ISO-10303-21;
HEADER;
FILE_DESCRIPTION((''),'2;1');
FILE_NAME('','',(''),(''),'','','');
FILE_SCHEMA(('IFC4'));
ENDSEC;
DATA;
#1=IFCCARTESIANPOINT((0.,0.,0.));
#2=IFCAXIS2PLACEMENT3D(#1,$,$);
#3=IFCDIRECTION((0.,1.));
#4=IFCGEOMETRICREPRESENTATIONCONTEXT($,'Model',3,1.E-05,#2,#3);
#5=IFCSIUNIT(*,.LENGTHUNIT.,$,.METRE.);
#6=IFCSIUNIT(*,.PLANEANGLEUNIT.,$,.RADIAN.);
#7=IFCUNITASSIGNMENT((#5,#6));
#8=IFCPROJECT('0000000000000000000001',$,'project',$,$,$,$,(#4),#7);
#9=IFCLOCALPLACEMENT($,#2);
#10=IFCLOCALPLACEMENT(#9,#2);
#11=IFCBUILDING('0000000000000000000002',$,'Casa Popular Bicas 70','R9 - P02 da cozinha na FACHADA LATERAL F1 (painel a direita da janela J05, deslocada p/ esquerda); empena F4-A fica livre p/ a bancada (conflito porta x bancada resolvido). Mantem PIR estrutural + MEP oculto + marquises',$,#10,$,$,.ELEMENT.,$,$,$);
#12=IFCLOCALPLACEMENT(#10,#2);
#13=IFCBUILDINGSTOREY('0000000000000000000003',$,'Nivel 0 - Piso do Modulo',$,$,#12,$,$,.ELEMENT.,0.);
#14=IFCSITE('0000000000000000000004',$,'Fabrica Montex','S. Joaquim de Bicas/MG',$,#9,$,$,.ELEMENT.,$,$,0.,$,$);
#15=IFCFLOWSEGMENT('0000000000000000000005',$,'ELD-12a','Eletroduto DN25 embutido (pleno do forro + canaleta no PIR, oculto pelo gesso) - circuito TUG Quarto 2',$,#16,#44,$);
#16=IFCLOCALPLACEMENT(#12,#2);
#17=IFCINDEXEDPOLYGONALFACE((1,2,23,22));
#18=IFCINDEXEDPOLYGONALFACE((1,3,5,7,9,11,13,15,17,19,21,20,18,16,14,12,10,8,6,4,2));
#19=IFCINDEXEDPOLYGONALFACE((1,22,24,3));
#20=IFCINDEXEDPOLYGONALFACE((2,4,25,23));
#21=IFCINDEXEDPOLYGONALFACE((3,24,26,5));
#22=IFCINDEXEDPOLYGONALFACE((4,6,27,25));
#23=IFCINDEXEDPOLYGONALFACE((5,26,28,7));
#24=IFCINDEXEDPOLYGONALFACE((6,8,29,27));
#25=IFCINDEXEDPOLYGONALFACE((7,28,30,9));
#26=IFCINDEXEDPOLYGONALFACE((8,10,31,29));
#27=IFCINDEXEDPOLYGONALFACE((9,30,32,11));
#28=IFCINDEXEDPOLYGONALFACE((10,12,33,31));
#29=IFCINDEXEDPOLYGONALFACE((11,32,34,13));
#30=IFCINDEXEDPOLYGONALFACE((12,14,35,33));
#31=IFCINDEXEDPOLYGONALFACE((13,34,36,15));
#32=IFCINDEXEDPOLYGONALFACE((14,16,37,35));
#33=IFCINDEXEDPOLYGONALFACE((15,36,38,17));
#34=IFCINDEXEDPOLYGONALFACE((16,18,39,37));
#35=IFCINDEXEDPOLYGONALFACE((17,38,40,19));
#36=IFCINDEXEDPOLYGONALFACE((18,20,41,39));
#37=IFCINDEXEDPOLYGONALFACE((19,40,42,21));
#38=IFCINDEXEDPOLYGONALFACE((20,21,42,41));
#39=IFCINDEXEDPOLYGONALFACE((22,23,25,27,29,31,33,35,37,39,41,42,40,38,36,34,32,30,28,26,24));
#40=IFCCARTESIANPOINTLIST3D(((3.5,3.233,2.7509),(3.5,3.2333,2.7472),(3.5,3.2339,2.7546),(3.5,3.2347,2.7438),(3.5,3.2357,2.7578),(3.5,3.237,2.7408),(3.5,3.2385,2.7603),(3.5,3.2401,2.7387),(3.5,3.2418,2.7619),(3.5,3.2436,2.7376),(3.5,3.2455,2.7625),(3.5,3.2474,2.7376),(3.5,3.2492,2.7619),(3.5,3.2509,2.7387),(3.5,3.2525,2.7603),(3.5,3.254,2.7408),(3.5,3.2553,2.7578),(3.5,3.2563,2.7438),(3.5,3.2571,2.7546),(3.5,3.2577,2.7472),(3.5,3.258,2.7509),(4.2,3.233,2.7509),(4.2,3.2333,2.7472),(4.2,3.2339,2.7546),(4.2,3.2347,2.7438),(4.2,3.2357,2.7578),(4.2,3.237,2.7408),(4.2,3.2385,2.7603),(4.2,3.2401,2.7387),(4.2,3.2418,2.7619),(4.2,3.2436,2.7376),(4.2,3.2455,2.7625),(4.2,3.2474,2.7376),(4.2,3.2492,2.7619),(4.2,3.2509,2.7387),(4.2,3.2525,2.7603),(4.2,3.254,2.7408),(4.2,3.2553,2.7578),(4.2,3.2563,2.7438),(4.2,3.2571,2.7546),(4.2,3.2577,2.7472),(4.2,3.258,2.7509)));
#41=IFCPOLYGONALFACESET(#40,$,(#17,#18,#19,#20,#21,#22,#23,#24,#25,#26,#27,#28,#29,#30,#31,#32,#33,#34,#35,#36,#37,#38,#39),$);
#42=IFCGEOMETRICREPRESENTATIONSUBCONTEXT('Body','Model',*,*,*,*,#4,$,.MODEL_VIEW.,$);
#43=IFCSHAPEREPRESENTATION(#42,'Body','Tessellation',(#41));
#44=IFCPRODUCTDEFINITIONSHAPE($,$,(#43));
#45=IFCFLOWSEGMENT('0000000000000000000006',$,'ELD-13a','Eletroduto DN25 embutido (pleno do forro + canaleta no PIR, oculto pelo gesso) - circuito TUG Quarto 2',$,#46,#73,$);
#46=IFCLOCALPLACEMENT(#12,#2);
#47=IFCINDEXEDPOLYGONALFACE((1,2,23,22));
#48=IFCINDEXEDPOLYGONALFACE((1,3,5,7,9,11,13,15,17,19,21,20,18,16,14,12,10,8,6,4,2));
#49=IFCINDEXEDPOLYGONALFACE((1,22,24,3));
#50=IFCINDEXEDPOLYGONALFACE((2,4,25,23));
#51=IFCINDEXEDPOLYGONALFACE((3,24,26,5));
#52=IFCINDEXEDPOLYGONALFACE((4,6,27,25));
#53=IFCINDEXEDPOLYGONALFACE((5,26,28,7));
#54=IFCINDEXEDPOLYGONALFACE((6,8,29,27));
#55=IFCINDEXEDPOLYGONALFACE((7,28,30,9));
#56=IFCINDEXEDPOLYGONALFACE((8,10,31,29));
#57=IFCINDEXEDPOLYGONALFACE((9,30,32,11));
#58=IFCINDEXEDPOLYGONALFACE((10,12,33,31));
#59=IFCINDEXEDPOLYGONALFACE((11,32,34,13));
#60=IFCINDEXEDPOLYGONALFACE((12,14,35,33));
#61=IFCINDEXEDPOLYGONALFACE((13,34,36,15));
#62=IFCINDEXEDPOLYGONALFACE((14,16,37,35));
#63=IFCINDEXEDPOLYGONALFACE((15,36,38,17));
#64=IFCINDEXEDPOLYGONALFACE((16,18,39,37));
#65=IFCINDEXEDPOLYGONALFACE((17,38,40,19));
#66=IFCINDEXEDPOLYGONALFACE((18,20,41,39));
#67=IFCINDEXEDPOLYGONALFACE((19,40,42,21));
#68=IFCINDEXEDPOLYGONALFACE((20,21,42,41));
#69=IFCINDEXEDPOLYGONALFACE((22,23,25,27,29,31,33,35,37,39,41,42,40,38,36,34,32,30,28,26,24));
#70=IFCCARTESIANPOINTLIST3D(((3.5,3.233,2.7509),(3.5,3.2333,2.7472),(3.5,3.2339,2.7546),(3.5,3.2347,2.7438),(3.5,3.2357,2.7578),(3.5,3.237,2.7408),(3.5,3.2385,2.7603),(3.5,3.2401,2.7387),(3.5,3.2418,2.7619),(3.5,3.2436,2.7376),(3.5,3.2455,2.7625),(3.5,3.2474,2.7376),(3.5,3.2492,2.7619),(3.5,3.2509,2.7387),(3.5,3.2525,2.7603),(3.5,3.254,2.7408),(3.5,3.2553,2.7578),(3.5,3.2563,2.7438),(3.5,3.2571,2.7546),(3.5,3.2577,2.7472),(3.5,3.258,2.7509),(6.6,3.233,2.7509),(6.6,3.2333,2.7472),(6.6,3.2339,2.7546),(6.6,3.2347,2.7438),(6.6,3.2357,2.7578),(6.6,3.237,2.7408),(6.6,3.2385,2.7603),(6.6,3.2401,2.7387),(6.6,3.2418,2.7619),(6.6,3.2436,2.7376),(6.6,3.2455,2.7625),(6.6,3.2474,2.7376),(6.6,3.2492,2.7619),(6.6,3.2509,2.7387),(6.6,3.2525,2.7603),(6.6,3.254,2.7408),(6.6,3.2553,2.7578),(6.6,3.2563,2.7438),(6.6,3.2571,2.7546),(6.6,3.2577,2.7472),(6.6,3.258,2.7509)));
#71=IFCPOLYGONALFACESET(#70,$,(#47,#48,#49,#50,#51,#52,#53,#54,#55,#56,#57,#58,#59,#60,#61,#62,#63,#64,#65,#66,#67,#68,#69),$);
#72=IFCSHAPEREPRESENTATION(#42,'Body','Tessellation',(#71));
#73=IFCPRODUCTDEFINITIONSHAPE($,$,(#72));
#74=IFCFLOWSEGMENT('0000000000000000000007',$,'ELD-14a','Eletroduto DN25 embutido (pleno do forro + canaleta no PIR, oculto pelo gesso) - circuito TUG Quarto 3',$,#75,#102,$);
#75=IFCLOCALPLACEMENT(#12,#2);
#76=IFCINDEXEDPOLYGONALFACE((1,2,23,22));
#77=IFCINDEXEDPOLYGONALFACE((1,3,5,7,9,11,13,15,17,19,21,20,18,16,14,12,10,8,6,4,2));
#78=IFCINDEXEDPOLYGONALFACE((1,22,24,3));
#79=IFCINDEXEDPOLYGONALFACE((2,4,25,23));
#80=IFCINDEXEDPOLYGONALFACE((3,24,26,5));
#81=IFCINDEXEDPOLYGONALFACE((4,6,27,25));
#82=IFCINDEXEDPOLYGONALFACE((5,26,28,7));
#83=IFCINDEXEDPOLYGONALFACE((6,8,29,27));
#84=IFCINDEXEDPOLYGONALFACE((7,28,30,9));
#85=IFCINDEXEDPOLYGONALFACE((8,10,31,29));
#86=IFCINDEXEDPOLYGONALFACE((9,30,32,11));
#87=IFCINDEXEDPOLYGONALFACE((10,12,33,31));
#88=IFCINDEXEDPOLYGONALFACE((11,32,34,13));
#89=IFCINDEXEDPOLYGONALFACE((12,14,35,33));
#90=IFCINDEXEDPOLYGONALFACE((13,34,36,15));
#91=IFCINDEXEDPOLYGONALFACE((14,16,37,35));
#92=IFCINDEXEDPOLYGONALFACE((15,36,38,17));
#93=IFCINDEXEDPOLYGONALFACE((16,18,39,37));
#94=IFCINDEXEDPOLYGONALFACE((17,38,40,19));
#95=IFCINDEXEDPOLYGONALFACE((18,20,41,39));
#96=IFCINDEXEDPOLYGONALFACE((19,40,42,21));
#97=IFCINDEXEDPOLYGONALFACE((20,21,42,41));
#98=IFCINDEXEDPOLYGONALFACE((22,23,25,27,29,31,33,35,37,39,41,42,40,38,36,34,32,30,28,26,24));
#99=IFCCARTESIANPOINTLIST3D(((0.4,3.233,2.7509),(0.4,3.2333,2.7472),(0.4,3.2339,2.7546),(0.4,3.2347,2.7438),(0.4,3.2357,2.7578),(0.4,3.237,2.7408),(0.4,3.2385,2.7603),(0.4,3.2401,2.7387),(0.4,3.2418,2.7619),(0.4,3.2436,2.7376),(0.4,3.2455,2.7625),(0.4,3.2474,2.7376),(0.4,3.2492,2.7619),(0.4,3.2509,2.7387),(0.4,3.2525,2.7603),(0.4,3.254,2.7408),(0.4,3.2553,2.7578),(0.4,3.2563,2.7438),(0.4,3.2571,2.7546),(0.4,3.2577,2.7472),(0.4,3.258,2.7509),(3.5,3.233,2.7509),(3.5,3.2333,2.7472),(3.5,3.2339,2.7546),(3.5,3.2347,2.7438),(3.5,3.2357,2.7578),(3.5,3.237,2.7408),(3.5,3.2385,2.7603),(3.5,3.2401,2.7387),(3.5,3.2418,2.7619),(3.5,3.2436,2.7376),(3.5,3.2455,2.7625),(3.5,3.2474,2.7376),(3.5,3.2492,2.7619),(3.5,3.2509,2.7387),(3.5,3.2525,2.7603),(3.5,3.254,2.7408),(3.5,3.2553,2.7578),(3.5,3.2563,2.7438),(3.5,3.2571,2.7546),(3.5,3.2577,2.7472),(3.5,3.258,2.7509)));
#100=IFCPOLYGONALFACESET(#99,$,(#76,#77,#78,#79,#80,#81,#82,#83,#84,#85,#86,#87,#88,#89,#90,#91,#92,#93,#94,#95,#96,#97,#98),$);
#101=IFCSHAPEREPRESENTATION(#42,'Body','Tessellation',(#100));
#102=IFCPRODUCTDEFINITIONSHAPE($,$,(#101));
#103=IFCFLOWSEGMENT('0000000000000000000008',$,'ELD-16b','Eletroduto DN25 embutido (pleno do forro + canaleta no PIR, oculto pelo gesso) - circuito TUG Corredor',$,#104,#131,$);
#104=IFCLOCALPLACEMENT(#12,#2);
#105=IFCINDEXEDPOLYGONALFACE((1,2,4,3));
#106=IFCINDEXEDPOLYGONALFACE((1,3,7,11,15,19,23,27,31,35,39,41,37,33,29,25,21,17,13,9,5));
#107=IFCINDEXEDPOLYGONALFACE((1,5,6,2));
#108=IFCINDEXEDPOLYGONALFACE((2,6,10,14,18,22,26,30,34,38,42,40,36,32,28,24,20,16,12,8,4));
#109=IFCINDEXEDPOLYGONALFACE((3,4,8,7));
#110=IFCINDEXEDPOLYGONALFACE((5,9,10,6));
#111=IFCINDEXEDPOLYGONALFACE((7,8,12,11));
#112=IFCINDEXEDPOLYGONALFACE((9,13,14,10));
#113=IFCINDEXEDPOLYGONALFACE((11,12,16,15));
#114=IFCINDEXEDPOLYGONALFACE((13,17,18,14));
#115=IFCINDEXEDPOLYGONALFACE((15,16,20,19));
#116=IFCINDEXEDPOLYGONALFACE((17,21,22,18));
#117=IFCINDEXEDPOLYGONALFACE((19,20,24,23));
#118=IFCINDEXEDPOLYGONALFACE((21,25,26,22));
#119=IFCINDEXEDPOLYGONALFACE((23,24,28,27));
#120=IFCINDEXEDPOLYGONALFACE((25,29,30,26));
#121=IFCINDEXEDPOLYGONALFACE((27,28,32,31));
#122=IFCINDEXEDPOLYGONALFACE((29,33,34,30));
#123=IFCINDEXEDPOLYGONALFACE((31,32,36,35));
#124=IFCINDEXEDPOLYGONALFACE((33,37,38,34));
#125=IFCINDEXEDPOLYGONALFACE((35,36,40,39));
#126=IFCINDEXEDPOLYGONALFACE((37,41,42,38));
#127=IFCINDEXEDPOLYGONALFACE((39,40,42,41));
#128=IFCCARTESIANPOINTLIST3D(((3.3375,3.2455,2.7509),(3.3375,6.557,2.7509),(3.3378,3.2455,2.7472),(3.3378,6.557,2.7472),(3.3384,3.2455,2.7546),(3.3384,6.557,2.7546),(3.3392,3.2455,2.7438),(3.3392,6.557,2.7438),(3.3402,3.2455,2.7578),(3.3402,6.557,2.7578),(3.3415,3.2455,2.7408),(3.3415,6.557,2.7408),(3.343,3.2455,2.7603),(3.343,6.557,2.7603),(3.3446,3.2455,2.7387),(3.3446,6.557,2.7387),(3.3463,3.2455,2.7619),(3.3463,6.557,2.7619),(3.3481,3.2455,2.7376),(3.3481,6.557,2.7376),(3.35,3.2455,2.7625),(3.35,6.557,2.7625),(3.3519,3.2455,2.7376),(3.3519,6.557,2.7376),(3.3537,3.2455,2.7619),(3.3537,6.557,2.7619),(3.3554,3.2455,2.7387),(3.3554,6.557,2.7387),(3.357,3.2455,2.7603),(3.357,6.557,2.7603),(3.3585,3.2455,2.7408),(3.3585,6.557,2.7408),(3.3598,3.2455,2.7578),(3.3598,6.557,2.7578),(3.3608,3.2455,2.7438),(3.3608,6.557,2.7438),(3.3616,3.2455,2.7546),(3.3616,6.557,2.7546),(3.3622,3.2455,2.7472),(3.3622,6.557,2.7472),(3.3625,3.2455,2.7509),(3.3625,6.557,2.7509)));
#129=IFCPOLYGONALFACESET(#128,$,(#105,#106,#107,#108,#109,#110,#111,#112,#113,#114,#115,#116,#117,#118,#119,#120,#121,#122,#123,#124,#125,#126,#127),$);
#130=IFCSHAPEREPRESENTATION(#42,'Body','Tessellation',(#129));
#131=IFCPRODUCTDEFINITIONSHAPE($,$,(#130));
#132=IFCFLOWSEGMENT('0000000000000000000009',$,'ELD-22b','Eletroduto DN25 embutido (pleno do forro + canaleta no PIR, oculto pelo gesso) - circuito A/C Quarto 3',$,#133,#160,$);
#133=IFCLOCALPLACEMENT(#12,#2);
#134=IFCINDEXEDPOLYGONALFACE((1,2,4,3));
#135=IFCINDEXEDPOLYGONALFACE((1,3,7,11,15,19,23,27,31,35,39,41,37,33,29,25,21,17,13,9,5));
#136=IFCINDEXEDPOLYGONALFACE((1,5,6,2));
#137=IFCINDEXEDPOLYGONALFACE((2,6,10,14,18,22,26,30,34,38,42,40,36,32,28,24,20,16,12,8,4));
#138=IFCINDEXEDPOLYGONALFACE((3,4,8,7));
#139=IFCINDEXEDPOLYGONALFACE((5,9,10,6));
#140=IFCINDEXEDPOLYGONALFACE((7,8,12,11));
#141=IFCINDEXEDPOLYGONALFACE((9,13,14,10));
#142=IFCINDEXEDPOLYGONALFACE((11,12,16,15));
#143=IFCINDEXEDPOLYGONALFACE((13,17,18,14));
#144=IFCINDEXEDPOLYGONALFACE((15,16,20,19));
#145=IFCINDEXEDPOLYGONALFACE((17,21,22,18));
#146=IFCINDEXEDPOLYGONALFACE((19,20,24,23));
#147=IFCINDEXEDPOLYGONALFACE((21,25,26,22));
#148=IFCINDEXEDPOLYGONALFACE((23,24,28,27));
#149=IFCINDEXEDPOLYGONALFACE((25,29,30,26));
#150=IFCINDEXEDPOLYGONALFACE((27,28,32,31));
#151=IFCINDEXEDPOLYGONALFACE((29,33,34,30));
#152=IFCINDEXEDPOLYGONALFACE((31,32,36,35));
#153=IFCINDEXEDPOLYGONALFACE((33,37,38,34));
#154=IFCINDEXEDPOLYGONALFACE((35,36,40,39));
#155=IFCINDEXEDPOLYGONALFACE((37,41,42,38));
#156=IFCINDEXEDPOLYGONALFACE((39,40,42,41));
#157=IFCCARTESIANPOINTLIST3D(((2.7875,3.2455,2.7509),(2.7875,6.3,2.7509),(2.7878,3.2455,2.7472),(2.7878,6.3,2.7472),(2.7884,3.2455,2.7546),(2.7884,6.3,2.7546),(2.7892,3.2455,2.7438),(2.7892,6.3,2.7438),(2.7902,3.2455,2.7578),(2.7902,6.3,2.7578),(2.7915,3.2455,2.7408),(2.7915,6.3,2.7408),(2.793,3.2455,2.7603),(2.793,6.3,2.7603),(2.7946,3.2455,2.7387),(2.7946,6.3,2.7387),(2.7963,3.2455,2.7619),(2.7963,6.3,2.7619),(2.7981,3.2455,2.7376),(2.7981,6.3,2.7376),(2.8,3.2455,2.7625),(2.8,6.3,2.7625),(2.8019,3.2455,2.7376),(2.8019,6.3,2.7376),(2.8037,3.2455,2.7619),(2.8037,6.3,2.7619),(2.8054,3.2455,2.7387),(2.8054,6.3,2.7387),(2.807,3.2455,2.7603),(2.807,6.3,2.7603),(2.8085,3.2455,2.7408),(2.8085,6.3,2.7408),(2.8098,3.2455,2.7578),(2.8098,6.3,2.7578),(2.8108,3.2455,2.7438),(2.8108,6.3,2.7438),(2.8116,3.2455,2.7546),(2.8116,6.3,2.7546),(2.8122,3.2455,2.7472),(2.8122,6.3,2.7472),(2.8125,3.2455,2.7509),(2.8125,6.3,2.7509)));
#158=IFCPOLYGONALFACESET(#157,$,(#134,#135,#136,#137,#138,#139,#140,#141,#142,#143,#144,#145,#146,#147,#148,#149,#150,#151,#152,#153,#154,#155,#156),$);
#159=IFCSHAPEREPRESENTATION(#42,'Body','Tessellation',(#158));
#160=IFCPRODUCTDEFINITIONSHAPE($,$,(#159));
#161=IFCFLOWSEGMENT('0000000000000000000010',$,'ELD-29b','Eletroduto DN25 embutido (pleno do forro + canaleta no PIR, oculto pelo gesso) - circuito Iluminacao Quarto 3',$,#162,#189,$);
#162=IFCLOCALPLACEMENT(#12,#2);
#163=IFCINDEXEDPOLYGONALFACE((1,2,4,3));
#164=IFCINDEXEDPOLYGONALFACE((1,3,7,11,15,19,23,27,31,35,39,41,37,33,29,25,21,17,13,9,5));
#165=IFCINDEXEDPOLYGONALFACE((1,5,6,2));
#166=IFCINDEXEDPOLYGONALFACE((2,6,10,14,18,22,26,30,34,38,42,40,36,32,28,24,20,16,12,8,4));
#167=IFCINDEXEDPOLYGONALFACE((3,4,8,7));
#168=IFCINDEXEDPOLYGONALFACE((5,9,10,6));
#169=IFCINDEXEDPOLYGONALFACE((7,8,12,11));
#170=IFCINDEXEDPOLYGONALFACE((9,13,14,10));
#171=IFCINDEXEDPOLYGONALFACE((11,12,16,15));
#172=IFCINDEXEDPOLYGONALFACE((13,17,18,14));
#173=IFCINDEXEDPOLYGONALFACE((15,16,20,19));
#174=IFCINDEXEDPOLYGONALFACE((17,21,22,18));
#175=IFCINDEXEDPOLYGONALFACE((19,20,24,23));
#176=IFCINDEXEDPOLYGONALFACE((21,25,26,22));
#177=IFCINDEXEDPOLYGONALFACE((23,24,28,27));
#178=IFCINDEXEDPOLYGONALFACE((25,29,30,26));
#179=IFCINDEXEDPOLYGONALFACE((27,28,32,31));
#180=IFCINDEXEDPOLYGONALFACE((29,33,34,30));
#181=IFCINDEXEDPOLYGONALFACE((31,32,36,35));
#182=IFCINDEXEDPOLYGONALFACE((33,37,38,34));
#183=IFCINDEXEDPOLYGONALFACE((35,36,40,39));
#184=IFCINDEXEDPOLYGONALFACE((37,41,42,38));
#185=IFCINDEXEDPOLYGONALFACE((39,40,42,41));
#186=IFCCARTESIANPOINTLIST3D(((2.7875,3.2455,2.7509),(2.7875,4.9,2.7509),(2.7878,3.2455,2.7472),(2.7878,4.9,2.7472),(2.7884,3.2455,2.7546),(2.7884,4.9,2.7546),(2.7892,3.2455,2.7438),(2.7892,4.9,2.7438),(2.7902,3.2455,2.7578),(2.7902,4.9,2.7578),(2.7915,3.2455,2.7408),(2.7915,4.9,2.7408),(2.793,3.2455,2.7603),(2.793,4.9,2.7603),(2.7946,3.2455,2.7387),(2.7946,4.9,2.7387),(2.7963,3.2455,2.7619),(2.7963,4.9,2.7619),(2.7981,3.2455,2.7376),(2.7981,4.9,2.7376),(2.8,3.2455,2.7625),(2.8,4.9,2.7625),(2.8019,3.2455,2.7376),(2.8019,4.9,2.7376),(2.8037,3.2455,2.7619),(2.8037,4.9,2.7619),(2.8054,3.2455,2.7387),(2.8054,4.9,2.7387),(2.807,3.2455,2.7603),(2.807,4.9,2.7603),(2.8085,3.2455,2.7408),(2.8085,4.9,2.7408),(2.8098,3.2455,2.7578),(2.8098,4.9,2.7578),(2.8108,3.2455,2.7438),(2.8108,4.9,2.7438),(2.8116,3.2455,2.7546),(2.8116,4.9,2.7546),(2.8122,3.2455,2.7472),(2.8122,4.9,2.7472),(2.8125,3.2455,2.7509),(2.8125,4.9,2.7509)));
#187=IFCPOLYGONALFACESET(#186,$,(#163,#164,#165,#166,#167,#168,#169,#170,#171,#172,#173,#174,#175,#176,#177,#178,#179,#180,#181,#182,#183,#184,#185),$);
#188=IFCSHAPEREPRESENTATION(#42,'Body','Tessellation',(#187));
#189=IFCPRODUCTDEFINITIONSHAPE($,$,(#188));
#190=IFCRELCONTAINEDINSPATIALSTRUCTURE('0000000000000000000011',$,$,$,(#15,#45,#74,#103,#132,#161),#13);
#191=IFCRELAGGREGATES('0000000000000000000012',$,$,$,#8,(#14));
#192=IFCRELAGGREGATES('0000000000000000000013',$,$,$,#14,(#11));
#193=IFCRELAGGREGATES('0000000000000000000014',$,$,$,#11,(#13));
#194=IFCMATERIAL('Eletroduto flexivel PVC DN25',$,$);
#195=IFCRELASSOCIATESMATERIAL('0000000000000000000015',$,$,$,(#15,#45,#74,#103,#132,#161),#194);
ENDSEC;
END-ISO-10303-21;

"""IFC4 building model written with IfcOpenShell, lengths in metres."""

from ifc_helpers import new_model, si_unit, direction, frame, origin, origin_2d, place, context, subcontext, project, spatial, circle, extrude, material, element, save


model = new_model("IFC4")

# Units and contexts
model_context = context("Model", 3, precision=1e-05, world=origin(), true_north=direction((0.0, 1.0)))
body_context = subcontext(model_context, "Body", "Model", "MODEL_VIEW")
ifc_project = project(units=[si_unit("LENGTHUNIT", "METRE"), si_unit("PLANEANGLEUNIT", "RADIAN")], contexts=[model_context])

# Site, building, storey
site_placement = place(None, origin())
site = spatial("IfcSite", under=ifc_project, at=site_placement, Name="Fabrica Montex", Description="S. Joaquim de Bicas/MG", CompositionType="ELEMENT", RefElevation=0.0)
building_placement = place(site_placement, origin())
building = spatial("IfcBuilding", under=site, at=building_placement, Name="Casa Popular Bicas 70", Description="R9 - P02 da cozinha na FACHADA LATERAL F1 (painel a direita da janela J05, deslocada p/ esquerda); empena F4-A fica livre p/ a bancada (conflito porta x bancada resolvido). Mantem PIR estrutural + MEP oculto + marquises", CompositionType="ELEMENT")
storey_placement = place(building_placement, origin())
storey = spatial("IfcBuildingStorey", under=building, at=storey_placement, Name="Nivel 0 - Piso do Modulo", CompositionType="ELEMENT", Elevation=0.0)

# Flow segments
ifc_material_1 = material(Name="Eletroduto flexivel PVC DN25")
flow_segment_1_placement = place(storey_placement, frame((3.5, 3.2455, 2.75), z_axis=(1.0, 0.0, 0.0), x_axis=(0.0, 0.0, 1.0)))
element("IfcFlowSegment", 1, at=flow_segment_1_placement, inside=storey, material=ifc_material_1, Name="ELD-12a", Description="Eletroduto DN25 embutido (pleno do forro + canaleta no PIR, oculto pelo gesso) - circuito TUG Quarto 2", context=body_context, shape_type="SweptSolid", body=[
    extrude(circle(Radius=0.0125, at=origin_2d()), origin(), (0.0, 0.0, 1.0), 0.7),
])
flow_segment_2_placement = place(storey_placement, frame((3.5, 3.2455, 2.75), z_axis=(1.0, 0.0, 0.0), x_axis=(0.0, 0.0, 1.0)))
element("IfcFlowSegment", 2, at=flow_segment_2_placement, inside=storey, material=ifc_material_1, Name="ELD-13a", Description="Eletroduto DN25 embutido (pleno do forro + canaleta no PIR, oculto pelo gesso) - circuito TUG Quarto 2", context=body_context, shape_type="SweptSolid", body=[
    extrude(circle(Radius=0.0125, at=origin_2d()), origin(), (0.0, 0.0, 1.0), 3.1),
])
flow_segment_3_placement = place(storey_placement, frame((3.5, 3.2455, 2.75), z_axis=(-1.0, 0.0, 0.0), x_axis=(0.0, 0.0, 1.0)))
element("IfcFlowSegment", 3, at=flow_segment_3_placement, inside=storey, material=ifc_material_1, Name="ELD-14a", Description="Eletroduto DN25 embutido (pleno do forro + canaleta no PIR, oculto pelo gesso) - circuito TUG Quarto 3", context=body_context, shape_type="SweptSolid", body=[
    extrude(circle(Radius=0.0125, at=origin_2d()), origin(), (0.0, 0.0, 1.0), 3.1),
])
flow_segment_4_placement = place(storey_placement, frame((3.35, 3.2455, 2.75), z_axis=(0.0, 1.0, 0.0), x_axis=(0.0, 0.0, 1.0)))
element("IfcFlowSegment", 4, at=flow_segment_4_placement, inside=storey, material=ifc_material_1, Name="ELD-16b", Description="Eletroduto DN25 embutido (pleno do forro + canaleta no PIR, oculto pelo gesso) - circuito TUG Corredor", context=body_context, shape_type="SweptSolid", body=[
    extrude(circle(Radius=0.0125, at=origin_2d()), origin(), (0.0, 0.0, 1.0), 3.3115),
])
flow_segment_5_placement = place(storey_placement, frame((2.8, 3.2455, 2.75), z_axis=(0.0, 1.0, 0.0), x_axis=(0.0, 0.0, 1.0)))
element("IfcFlowSegment", 5, at=flow_segment_5_placement, inside=storey, material=ifc_material_1, Name="ELD-22b", Description="Eletroduto DN25 embutido (pleno do forro + canaleta no PIR, oculto pelo gesso) - circuito A/C Quarto 3", context=body_context, shape_type="SweptSolid", body=[
    extrude(circle(Radius=0.0125, at=origin_2d()), origin(), (0.0, 0.0, 1.0), 3.0545),
])
flow_segment_6_placement = place(storey_placement, frame((2.8, 3.2455, 2.75), z_axis=(0.0, 1.0, 0.0), x_axis=(0.0, 0.0, 1.0)))
element("IfcFlowSegment", 6, at=flow_segment_6_placement, inside=storey, material=ifc_material_1, Name="ELD-29b", Description="Eletroduto DN25 embutido (pleno do forro + canaleta no PIR, oculto pelo gesso) - circuito Iluminacao Quarto 3", context=body_context, shape_type="SweptSolid", body=[
    extrude(circle(Radius=0.0125, at=origin_2d()), origin(), (0.0, 0.0, 1.0), 1.6545),
])

save(model, "model.ifc")
